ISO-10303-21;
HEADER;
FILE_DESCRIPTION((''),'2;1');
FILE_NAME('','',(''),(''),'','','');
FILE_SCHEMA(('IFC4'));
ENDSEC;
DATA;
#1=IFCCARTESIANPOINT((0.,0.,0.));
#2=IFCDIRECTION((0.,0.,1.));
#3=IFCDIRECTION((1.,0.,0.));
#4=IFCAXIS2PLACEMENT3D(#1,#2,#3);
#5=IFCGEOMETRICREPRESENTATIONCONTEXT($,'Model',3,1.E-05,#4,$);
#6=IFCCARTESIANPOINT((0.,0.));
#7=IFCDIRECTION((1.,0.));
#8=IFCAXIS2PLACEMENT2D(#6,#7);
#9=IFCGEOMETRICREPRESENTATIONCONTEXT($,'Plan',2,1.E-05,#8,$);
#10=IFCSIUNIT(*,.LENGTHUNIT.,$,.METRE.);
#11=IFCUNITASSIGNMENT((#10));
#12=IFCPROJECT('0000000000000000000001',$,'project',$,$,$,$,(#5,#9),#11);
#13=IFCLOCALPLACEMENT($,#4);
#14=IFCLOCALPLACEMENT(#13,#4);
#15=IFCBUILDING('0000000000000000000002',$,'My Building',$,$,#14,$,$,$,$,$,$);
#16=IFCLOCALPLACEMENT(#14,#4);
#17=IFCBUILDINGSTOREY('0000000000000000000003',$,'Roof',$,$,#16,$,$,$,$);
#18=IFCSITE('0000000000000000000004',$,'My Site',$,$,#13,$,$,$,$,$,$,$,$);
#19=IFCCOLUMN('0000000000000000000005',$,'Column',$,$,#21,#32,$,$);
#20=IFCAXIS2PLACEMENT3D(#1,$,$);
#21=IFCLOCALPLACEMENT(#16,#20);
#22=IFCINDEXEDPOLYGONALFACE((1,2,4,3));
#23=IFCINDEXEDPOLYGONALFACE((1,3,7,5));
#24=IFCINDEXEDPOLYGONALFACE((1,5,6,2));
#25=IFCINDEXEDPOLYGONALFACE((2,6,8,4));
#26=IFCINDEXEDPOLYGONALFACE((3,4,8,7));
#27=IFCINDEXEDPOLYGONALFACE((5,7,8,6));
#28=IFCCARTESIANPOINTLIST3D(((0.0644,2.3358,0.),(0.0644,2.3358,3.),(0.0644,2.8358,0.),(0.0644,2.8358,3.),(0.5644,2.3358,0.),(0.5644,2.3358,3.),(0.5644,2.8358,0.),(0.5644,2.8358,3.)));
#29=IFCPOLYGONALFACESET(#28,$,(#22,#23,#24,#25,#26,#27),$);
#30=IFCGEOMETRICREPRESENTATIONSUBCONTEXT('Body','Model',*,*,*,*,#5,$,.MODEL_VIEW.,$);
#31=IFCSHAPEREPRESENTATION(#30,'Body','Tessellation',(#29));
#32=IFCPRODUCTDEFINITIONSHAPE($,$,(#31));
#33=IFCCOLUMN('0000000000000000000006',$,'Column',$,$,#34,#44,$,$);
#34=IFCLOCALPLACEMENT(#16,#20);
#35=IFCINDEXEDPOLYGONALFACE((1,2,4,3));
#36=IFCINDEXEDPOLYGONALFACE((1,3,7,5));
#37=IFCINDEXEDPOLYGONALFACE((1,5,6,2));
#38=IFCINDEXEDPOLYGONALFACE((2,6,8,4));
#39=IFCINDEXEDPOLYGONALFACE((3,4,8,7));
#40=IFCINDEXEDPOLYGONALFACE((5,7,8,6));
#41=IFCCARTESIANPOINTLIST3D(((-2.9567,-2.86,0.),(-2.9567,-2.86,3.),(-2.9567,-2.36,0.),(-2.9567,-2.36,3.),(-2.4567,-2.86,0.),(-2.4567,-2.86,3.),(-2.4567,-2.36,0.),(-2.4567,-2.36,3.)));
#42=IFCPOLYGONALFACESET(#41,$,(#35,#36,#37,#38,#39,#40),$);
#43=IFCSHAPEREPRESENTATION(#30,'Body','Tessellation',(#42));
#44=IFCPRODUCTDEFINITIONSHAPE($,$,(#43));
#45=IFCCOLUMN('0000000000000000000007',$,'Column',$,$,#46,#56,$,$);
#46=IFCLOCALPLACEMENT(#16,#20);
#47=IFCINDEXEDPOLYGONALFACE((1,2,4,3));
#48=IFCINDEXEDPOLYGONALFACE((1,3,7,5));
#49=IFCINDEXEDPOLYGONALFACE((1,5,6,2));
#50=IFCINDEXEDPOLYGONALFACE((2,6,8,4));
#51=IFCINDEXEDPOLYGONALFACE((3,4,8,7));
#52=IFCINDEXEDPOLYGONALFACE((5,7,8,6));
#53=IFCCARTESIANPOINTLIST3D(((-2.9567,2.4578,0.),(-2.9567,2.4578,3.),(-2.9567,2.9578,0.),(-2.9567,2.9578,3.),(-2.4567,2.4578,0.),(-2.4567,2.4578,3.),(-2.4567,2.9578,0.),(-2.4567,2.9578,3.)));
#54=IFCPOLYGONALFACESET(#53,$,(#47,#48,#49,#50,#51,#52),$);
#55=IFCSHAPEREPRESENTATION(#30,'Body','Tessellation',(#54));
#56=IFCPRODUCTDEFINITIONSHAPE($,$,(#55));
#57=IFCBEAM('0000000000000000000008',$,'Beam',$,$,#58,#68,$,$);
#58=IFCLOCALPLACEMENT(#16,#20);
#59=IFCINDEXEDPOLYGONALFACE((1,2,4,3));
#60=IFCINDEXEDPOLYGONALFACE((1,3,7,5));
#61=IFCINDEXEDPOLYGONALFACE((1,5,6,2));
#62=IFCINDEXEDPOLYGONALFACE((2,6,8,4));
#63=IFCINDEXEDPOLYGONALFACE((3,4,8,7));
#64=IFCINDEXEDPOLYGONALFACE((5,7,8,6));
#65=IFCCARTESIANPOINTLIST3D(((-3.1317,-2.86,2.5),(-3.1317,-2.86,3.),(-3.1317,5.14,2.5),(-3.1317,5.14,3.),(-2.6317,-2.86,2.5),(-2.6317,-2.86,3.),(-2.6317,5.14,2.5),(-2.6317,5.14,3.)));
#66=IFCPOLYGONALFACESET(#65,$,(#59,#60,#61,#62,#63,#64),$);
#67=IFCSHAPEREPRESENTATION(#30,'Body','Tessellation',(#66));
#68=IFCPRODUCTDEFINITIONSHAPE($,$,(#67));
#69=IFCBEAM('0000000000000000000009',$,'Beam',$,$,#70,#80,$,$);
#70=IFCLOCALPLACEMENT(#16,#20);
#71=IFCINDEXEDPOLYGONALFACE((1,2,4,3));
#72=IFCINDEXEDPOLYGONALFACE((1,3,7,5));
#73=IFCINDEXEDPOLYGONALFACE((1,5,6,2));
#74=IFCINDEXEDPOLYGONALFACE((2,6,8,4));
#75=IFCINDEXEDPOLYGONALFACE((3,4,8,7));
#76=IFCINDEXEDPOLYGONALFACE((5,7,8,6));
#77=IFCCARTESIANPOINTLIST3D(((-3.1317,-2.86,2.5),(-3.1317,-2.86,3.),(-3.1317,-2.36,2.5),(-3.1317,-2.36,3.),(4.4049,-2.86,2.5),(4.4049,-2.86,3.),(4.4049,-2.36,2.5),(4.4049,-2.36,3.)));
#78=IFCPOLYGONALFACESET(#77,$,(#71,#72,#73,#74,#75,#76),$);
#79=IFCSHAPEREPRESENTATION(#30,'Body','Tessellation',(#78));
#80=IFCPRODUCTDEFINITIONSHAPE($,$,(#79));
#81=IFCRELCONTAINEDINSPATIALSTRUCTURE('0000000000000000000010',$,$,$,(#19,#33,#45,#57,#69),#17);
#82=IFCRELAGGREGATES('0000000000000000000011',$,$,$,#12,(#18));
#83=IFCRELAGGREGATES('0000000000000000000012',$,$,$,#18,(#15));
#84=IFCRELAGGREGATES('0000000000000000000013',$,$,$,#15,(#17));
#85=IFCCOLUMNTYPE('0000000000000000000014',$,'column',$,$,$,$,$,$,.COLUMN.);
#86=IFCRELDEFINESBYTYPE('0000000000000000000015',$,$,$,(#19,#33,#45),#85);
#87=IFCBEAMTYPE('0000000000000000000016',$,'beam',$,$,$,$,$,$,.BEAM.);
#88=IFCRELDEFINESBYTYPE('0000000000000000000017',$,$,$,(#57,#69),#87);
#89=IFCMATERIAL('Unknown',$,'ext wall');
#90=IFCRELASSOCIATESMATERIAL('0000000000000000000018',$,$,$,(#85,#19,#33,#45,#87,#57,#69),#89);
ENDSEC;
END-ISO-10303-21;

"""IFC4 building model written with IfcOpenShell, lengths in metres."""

from ifc_helpers import new_model, si_unit, frame, origin_with_axes, origin_2d_with_axis, place, context, subcontext, project, spatial, rectangle, extrude, material, material_profile, profile_set, profile_usage, type_object, element, save


model = new_model("IFC4")

# Units and contexts
model_context = context("Model", 3, precision=1e-05, world=origin_with_axes())
plan_context = context("Plan", 2, precision=1e-05, world=origin_2d_with_axis())
body_context = subcontext(model_context, "Body", "Model", "MODEL_VIEW")
ifc_project = project(units=[si_unit("LENGTHUNIT", "METRE")], contexts=[model_context, plan_context])

# Site, building, storey
site_placement = place(None, origin_with_axes())
site = spatial("IfcSite", under=ifc_project, at=site_placement, Name="My Site")
building_placement = place(site_placement, origin_with_axes())
building = spatial("IfcBuilding", under=site, at=building_placement, Name="My Building")
storey_placement = place(building_placement, origin_with_axes())
storey = spatial("IfcBuildingStorey", under=building, at=storey_placement, Name="Roof")

# Columns
ifc_material = material(Name="Unknown", Category="ext wall")
ifc_material_profile_1 = material_profile(ifc_material, rectangle(XDim=0.5, YDim=0.5))
ifc_profile_set_1 = profile_set([ifc_material_profile_1])
ifc_profile_usage_1 = profile_usage(ifc_profile_set_1, cardinal=5)
column_type = type_object("IfcColumnType", Name="column", PredefinedType="COLUMN", material=ifc_profile_set_1)
column_1_placement = place(storey_placement, frame((0.3144, 2.5858, 0.0), z_axis=(0.0, 0.0, 1.0), x_axis=(1.0, 0.0, 0.0)))
element("IfcColumn", 1, at=column_1_placement, inside=storey, type_object=column_type, material=ifc_profile_usage_1, Name="Column", context=body_context, shape_type="SweptSolid", body=[
    extrude(rectangle(XDim=0.5, YDim=0.5), origin_with_axes(), (0.0, 0.0, 1.0), 3.0),
])
ifc_profile_usage_2 = profile_usage(ifc_profile_set_1, cardinal=5)
column_2_placement = place(storey_placement, frame((-2.7067, -2.61, 0.0), z_axis=(0.0, 0.0, 1.0), x_axis=(1.0, 0.0, 0.0)))
element("IfcColumn", 2, at=column_2_placement, inside=storey, type_object=column_type, material=ifc_profile_usage_2, Name="Column", context=body_context, shape_type="SweptSolid", body=[
    extrude(rectangle(XDim=0.5, YDim=0.5), origin_with_axes(), (0.0, 0.0, 1.0), 3.0),
])
ifc_profile_usage_3 = profile_usage(ifc_profile_set_1, cardinal=5)
column_3_placement = place(storey_placement, frame((-2.7067, 2.7078, 0.0), z_axis=(0.0, 0.0, 1.0), x_axis=(1.0, 0.0, 0.0)))
element("IfcColumn", 3, at=column_3_placement, inside=storey, type_object=column_type, material=ifc_profile_usage_3, Name="Column", context=body_context, shape_type="SweptSolid", body=[
    extrude(rectangle(XDim=0.5, YDim=0.5), origin_with_axes(), (0.0, 0.0, 1.0), 3.0),
])

# Beams
ifc_material_profile_2 = material_profile(ifc_material, rectangle(XDim=0.5, YDim=0.5))
ifc_profile_set_2 = profile_set([ifc_material_profile_2])
ifc_profile_usage_4 = profile_usage(ifc_profile_set_2, cardinal=7)
beam_type = type_object("IfcBeamType", Name="beam", PredefinedType="BEAM", material=ifc_profile_set_2)
beam_1_placement = place(storey_placement, frame((-2.6317, 5.14, 3.0), z_axis=(0.0, -1.0, 0.0), x_axis=(1.0, 0.0, 0.0)))
element("IfcBeam", 4, at=beam_1_placement, inside=storey, type_object=beam_type, material=ifc_profile_usage_4, Name="Beam", context=body_context, shape_type="SweptSolid", body=[
    extrude(rectangle(XDim=0.5, YDim=0.5), frame((-0.25, -0.25, 0.0), z_axis=(0.0, 0.0, 1.0), x_axis=(1.0, 0.0, 0.0)), (0.0, 0.0, 1.0), 8.0),
])
ifc_profile_usage_5 = profile_usage(ifc_profile_set_2, cardinal=7)
beam_2_placement = place(storey_placement, frame((-3.1317, -2.36, 3.0), z_axis=(1.0, 0.0, 0.0), x_axis=(0.0, 1.0, 0.0)))
element("IfcBeam", 5, at=beam_2_placement, inside=storey, type_object=beam_type, material=ifc_profile_usage_5, Name="Beam", context=body_context, shape_type="SweptSolid", body=[
    extrude(rectangle(XDim=0.5, YDim=0.5), frame((-0.25, -0.25, 0.0), z_axis=(0.0, 0.0, 1.0), x_axis=(1.0, 0.0, 0.0)), (0.0, 0.0, 1.0), 7.5366),
])

save(model, "model.ifc")
